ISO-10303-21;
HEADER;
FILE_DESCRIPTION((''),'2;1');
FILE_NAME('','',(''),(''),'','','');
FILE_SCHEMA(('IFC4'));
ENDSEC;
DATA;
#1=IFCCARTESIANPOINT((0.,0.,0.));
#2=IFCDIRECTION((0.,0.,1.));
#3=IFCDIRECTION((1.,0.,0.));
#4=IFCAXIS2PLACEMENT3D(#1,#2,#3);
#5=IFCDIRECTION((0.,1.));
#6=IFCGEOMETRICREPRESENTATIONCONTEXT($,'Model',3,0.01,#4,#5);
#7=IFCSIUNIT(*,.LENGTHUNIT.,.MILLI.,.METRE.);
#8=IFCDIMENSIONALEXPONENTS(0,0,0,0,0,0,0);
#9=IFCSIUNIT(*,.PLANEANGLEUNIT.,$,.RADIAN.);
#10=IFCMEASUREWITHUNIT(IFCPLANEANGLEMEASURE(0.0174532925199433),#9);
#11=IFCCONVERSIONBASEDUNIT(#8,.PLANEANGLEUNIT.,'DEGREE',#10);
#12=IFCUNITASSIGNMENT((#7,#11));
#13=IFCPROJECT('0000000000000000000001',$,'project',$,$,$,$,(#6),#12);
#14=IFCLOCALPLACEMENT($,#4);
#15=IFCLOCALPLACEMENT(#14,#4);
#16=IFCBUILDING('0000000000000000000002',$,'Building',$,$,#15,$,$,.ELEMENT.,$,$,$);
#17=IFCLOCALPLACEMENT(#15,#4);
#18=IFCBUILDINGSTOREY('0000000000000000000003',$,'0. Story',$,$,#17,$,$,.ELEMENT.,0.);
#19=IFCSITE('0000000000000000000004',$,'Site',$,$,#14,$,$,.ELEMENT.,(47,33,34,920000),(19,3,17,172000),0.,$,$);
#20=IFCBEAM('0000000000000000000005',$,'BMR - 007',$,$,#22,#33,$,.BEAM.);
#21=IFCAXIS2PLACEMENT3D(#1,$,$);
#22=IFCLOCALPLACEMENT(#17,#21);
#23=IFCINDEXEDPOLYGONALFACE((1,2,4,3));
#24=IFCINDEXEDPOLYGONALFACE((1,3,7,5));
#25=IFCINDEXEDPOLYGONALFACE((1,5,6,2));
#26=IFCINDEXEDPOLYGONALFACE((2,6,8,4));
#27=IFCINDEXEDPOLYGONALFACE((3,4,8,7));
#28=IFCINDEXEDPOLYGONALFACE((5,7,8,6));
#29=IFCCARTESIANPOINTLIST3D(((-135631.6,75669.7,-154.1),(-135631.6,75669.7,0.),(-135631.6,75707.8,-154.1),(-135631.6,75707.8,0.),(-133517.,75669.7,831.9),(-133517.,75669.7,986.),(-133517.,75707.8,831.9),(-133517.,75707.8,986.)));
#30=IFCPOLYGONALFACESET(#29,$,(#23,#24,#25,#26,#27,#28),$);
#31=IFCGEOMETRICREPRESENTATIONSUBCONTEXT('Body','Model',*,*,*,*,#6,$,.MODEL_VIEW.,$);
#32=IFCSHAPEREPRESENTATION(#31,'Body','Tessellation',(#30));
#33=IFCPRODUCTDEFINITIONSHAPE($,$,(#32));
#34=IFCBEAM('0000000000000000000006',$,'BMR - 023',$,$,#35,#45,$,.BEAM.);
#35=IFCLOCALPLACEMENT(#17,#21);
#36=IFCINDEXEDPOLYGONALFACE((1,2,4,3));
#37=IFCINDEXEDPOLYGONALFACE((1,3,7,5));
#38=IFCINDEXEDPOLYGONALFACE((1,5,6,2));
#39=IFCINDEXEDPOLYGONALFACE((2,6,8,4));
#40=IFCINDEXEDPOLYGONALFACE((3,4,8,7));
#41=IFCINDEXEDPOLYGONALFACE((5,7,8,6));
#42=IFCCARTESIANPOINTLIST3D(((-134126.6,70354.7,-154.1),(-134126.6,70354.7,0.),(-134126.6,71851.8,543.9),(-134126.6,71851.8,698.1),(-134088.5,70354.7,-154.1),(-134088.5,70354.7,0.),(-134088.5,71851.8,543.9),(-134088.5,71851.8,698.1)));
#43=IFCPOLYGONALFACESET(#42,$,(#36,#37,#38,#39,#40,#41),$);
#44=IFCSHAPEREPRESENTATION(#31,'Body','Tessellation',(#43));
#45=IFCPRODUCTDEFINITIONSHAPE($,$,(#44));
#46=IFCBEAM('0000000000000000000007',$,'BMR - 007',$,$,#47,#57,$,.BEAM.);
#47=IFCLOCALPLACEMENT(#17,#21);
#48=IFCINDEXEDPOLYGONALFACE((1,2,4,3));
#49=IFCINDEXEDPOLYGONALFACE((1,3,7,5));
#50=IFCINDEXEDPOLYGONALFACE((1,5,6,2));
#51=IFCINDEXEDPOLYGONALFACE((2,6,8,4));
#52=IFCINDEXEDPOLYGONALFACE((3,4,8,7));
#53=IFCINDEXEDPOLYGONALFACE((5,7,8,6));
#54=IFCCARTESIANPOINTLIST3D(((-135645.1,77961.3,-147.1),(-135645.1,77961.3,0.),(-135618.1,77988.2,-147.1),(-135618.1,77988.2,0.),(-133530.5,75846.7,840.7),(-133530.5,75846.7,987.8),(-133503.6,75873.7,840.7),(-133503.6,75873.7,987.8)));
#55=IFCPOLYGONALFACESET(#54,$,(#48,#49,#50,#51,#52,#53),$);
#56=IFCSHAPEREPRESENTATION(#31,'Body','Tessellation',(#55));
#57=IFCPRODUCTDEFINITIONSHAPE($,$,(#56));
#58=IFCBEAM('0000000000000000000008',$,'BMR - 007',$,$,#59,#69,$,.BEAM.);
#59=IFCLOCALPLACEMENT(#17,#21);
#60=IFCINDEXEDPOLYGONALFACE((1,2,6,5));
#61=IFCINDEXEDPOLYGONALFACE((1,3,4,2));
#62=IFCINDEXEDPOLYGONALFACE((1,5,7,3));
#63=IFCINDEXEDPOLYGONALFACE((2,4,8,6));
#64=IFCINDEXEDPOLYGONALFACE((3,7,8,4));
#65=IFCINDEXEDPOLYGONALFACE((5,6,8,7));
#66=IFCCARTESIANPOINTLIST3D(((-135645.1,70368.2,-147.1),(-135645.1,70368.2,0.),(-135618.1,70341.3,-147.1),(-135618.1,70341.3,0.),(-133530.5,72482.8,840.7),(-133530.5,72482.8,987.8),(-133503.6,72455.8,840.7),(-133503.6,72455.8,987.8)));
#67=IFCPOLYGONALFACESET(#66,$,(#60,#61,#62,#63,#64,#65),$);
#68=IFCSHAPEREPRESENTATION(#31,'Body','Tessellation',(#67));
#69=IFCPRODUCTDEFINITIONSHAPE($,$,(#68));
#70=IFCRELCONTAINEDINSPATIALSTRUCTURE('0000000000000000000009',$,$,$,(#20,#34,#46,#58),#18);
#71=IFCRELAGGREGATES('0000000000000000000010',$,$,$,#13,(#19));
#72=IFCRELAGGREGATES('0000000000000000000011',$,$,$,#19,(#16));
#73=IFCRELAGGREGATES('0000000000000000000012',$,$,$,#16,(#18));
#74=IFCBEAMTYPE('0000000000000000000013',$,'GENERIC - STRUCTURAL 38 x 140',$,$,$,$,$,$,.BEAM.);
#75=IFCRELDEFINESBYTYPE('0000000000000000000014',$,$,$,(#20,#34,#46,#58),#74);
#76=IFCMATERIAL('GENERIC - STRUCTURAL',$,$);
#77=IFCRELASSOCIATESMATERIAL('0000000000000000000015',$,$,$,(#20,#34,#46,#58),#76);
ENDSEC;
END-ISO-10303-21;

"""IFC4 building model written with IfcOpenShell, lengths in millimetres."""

from ifc_helpers import new_model, entity, si_unit, converted_unit, direction, frame, frame_2d, origin_with_axes, place, context, subcontext, project, spatial, rectangle, extrude, clip, halfspace, material, type_object, element, save


model = new_model("IFC4")

# Units and contexts
model_context = context("Model", 3, precision=0.01, world=origin_with_axes(), true_north=direction((0.0, 1.0)))
body_context = subcontext(model_context, "Body", "Model", "MODEL_VIEW")
ifc_project = project(units=[si_unit("LENGTHUNIT", "METRE", prefix="MILLI"), converted_unit("PLANEANGLEUNIT", "DEGREE", entity("IfcPlaneAngleMeasure", 0.0174532925199433), si_unit("PLANEANGLEUNIT", "RADIAN"), dimensions=[0, 0, 0, 0, 0, 0, 0])], contexts=[model_context])

# Site, building, storey
site_placement = place(None, origin_with_axes())
site = spatial("IfcSite", under=ifc_project, at=site_placement, Name="Site", CompositionType="ELEMENT", RefLatitude=(47, 33, 34, 920000), RefLongitude=(19, 3, 17, 172000), RefElevation=0.0)
building_placement = place(site_placement, origin_with_axes())
building = spatial("IfcBuilding", under=site, at=building_placement, Name="Building", CompositionType="ELEMENT")
storey_placement = place(building_placement, origin_with_axes())
storey = spatial("IfcBuildingStorey", under=building, at=storey_placement, Name="0. Story", CompositionType="ELEMENT", Elevation=0.0)

# Beams
ifc_material = material(Name="GENERIC - STRUCTURAL")
beam_type = type_object("IfcBeamType", Name="GENERIC - STRUCTURAL 38 x 140", PredefinedType="BEAM")
for number, where, z_axis, x_axis, name in (
    (1, (-135631.6, 75688.7, 0.0), (0.0, 0.0, 1.0), (0.0, -1.0, 0.0), "BMR - 007"),
):
    element("IfcBeam", number, at=place(storey_placement, frame(where, z_axis=z_axis, x_axis=x_axis)), inside=storey, type_object=beam_type, material=ifc_material, Name=name, PredefinedType="BEAM", context=body_context, shape_type="Clipping", body=[
        clip(clip(extrude(rectangle(XDim=139.7, YDim=38.1, at=frame_2d((-69.8, 0.0), x_axis=(1.0, 0.0))), frame((0.0, -83.5, -38.9), z_axis=(0.0, 0.906308, 0.422618), x_axis=(0.0, -0.422618, 0.906308)), (0.0, 0.0, 1.0), 2517.4), halfspace(frame((0.0, 0.0, 0.0), z_axis=(0.0, 1.0, 0.0), x_axis=(0.0, 0.0, 1.0)), True)), halfspace(frame((0.0, 2114.5, 0.0), z_axis=(0.0, -1.0, 0.0), x_axis=(0.0, 0.0, -1.0)), True)),
    ])
beam_1_placement = place(storey_placement, frame((-134107.6, 70354.7, 0.0), z_axis=(0.0, 0.0, 1.0), x_axis=(1.0, 0.0, 0.0)))
element("IfcBeam", 2, at=beam_1_placement, inside=storey, type_object=beam_type, material=ifc_material, Name="BMR - 023", PredefinedType="BEAM", context=body_context, shape_type="Clipping", body=[
    clip(clip(extrude(rectangle(XDim=139.7, YDim=38.1, at=frame_2d((-69.8, 0.0), x_axis=(1.0, 0.0))), frame((0.0, -83.5, -38.9), z_axis=(0.0, 0.906308, 0.422618), x_axis=(0.0, -0.422618, 0.906308)), (0.0, 0.0, 1.0), 1836.1), halfspace(frame((0.0, 0.0, 0.0), z_axis=(0.0, 1.0, 0.0), x_axis=(0.0, 0.0, 1.0)), True)), halfspace(frame((0.0, 1497.1, 0.0), z_axis=(0.0, -1.0, 0.0), x_axis=(0.0, 0.0, -1.0)), True)),
])
beam_2_placement = place(storey_placement, frame((-135631.6, 77974.7, 0.0), z_axis=(0.0, 0.0, 1.0), x_axis=(-0.707107, -0.707107, 0.0)))
element("IfcBeam", 3, at=beam_2_placement, inside=storey, type_object=beam_type, material=ifc_material, Name="BMR - 007", PredefinedType="BEAM", context=body_context, shape_type="Clipping", body=[
    clip(clip(extrude(rectangle(XDim=139.7, YDim=38.1, at=frame_2d((-69.8, 0.0), x_axis=(1.0, 0.0))), frame((0.0, -62.0, -20.5), z_axis=(0.0, 0.94954, 0.313647), x_axis=(0.0, -0.313647, 0.94954)), (0.0, 0.0, 1.0), 3279.9), halfspace(frame((0.0, 0.0, 0.0), z_axis=(0.0, 1.0, 0.0), x_axis=(0.0, 0.0, 1.0)), True)), halfspace(frame((0.0, 2990.4, 0.0), z_axis=(0.0, -1.0, 0.0), x_axis=(0.0, 0.0, -1.0)), True)),
])
beam_3_placement = place(storey_placement, frame((-135631.6, 70354.7, 0.0), z_axis=(0.0, 0.0, 1.0), x_axis=(0.707107, -0.707107, 0.0)))
element("IfcBeam", 4, at=beam_3_placement, inside=storey, type_object=beam_type, material=ifc_material, Name="BMR - 007", PredefinedType="BEAM", context=body_context, shape_type="Clipping", body=[
    clip(clip(extrude(rectangle(XDim=139.7, YDim=38.1, at=frame_2d((-69.8, 0.0), x_axis=(1.0, 0.0))), frame((0.0, -62.0, -20.5), z_axis=(0.0, 0.94954, 0.313647), x_axis=(0.0, -0.313647, 0.94954)), (0.0, 0.0, 1.0), 3279.9), halfspace(frame((0.0, 0.0, 0.0), z_axis=(0.0, 1.0, 0.0), x_axis=(0.0, 0.0, 1.0)), True)), halfspace(frame((0.0, 2990.4, 0.0), z_axis=(0.0, -1.0, 0.0), x_axis=(0.0, 0.0, -1.0)), True)),
])

save(model, "model.ifc")
